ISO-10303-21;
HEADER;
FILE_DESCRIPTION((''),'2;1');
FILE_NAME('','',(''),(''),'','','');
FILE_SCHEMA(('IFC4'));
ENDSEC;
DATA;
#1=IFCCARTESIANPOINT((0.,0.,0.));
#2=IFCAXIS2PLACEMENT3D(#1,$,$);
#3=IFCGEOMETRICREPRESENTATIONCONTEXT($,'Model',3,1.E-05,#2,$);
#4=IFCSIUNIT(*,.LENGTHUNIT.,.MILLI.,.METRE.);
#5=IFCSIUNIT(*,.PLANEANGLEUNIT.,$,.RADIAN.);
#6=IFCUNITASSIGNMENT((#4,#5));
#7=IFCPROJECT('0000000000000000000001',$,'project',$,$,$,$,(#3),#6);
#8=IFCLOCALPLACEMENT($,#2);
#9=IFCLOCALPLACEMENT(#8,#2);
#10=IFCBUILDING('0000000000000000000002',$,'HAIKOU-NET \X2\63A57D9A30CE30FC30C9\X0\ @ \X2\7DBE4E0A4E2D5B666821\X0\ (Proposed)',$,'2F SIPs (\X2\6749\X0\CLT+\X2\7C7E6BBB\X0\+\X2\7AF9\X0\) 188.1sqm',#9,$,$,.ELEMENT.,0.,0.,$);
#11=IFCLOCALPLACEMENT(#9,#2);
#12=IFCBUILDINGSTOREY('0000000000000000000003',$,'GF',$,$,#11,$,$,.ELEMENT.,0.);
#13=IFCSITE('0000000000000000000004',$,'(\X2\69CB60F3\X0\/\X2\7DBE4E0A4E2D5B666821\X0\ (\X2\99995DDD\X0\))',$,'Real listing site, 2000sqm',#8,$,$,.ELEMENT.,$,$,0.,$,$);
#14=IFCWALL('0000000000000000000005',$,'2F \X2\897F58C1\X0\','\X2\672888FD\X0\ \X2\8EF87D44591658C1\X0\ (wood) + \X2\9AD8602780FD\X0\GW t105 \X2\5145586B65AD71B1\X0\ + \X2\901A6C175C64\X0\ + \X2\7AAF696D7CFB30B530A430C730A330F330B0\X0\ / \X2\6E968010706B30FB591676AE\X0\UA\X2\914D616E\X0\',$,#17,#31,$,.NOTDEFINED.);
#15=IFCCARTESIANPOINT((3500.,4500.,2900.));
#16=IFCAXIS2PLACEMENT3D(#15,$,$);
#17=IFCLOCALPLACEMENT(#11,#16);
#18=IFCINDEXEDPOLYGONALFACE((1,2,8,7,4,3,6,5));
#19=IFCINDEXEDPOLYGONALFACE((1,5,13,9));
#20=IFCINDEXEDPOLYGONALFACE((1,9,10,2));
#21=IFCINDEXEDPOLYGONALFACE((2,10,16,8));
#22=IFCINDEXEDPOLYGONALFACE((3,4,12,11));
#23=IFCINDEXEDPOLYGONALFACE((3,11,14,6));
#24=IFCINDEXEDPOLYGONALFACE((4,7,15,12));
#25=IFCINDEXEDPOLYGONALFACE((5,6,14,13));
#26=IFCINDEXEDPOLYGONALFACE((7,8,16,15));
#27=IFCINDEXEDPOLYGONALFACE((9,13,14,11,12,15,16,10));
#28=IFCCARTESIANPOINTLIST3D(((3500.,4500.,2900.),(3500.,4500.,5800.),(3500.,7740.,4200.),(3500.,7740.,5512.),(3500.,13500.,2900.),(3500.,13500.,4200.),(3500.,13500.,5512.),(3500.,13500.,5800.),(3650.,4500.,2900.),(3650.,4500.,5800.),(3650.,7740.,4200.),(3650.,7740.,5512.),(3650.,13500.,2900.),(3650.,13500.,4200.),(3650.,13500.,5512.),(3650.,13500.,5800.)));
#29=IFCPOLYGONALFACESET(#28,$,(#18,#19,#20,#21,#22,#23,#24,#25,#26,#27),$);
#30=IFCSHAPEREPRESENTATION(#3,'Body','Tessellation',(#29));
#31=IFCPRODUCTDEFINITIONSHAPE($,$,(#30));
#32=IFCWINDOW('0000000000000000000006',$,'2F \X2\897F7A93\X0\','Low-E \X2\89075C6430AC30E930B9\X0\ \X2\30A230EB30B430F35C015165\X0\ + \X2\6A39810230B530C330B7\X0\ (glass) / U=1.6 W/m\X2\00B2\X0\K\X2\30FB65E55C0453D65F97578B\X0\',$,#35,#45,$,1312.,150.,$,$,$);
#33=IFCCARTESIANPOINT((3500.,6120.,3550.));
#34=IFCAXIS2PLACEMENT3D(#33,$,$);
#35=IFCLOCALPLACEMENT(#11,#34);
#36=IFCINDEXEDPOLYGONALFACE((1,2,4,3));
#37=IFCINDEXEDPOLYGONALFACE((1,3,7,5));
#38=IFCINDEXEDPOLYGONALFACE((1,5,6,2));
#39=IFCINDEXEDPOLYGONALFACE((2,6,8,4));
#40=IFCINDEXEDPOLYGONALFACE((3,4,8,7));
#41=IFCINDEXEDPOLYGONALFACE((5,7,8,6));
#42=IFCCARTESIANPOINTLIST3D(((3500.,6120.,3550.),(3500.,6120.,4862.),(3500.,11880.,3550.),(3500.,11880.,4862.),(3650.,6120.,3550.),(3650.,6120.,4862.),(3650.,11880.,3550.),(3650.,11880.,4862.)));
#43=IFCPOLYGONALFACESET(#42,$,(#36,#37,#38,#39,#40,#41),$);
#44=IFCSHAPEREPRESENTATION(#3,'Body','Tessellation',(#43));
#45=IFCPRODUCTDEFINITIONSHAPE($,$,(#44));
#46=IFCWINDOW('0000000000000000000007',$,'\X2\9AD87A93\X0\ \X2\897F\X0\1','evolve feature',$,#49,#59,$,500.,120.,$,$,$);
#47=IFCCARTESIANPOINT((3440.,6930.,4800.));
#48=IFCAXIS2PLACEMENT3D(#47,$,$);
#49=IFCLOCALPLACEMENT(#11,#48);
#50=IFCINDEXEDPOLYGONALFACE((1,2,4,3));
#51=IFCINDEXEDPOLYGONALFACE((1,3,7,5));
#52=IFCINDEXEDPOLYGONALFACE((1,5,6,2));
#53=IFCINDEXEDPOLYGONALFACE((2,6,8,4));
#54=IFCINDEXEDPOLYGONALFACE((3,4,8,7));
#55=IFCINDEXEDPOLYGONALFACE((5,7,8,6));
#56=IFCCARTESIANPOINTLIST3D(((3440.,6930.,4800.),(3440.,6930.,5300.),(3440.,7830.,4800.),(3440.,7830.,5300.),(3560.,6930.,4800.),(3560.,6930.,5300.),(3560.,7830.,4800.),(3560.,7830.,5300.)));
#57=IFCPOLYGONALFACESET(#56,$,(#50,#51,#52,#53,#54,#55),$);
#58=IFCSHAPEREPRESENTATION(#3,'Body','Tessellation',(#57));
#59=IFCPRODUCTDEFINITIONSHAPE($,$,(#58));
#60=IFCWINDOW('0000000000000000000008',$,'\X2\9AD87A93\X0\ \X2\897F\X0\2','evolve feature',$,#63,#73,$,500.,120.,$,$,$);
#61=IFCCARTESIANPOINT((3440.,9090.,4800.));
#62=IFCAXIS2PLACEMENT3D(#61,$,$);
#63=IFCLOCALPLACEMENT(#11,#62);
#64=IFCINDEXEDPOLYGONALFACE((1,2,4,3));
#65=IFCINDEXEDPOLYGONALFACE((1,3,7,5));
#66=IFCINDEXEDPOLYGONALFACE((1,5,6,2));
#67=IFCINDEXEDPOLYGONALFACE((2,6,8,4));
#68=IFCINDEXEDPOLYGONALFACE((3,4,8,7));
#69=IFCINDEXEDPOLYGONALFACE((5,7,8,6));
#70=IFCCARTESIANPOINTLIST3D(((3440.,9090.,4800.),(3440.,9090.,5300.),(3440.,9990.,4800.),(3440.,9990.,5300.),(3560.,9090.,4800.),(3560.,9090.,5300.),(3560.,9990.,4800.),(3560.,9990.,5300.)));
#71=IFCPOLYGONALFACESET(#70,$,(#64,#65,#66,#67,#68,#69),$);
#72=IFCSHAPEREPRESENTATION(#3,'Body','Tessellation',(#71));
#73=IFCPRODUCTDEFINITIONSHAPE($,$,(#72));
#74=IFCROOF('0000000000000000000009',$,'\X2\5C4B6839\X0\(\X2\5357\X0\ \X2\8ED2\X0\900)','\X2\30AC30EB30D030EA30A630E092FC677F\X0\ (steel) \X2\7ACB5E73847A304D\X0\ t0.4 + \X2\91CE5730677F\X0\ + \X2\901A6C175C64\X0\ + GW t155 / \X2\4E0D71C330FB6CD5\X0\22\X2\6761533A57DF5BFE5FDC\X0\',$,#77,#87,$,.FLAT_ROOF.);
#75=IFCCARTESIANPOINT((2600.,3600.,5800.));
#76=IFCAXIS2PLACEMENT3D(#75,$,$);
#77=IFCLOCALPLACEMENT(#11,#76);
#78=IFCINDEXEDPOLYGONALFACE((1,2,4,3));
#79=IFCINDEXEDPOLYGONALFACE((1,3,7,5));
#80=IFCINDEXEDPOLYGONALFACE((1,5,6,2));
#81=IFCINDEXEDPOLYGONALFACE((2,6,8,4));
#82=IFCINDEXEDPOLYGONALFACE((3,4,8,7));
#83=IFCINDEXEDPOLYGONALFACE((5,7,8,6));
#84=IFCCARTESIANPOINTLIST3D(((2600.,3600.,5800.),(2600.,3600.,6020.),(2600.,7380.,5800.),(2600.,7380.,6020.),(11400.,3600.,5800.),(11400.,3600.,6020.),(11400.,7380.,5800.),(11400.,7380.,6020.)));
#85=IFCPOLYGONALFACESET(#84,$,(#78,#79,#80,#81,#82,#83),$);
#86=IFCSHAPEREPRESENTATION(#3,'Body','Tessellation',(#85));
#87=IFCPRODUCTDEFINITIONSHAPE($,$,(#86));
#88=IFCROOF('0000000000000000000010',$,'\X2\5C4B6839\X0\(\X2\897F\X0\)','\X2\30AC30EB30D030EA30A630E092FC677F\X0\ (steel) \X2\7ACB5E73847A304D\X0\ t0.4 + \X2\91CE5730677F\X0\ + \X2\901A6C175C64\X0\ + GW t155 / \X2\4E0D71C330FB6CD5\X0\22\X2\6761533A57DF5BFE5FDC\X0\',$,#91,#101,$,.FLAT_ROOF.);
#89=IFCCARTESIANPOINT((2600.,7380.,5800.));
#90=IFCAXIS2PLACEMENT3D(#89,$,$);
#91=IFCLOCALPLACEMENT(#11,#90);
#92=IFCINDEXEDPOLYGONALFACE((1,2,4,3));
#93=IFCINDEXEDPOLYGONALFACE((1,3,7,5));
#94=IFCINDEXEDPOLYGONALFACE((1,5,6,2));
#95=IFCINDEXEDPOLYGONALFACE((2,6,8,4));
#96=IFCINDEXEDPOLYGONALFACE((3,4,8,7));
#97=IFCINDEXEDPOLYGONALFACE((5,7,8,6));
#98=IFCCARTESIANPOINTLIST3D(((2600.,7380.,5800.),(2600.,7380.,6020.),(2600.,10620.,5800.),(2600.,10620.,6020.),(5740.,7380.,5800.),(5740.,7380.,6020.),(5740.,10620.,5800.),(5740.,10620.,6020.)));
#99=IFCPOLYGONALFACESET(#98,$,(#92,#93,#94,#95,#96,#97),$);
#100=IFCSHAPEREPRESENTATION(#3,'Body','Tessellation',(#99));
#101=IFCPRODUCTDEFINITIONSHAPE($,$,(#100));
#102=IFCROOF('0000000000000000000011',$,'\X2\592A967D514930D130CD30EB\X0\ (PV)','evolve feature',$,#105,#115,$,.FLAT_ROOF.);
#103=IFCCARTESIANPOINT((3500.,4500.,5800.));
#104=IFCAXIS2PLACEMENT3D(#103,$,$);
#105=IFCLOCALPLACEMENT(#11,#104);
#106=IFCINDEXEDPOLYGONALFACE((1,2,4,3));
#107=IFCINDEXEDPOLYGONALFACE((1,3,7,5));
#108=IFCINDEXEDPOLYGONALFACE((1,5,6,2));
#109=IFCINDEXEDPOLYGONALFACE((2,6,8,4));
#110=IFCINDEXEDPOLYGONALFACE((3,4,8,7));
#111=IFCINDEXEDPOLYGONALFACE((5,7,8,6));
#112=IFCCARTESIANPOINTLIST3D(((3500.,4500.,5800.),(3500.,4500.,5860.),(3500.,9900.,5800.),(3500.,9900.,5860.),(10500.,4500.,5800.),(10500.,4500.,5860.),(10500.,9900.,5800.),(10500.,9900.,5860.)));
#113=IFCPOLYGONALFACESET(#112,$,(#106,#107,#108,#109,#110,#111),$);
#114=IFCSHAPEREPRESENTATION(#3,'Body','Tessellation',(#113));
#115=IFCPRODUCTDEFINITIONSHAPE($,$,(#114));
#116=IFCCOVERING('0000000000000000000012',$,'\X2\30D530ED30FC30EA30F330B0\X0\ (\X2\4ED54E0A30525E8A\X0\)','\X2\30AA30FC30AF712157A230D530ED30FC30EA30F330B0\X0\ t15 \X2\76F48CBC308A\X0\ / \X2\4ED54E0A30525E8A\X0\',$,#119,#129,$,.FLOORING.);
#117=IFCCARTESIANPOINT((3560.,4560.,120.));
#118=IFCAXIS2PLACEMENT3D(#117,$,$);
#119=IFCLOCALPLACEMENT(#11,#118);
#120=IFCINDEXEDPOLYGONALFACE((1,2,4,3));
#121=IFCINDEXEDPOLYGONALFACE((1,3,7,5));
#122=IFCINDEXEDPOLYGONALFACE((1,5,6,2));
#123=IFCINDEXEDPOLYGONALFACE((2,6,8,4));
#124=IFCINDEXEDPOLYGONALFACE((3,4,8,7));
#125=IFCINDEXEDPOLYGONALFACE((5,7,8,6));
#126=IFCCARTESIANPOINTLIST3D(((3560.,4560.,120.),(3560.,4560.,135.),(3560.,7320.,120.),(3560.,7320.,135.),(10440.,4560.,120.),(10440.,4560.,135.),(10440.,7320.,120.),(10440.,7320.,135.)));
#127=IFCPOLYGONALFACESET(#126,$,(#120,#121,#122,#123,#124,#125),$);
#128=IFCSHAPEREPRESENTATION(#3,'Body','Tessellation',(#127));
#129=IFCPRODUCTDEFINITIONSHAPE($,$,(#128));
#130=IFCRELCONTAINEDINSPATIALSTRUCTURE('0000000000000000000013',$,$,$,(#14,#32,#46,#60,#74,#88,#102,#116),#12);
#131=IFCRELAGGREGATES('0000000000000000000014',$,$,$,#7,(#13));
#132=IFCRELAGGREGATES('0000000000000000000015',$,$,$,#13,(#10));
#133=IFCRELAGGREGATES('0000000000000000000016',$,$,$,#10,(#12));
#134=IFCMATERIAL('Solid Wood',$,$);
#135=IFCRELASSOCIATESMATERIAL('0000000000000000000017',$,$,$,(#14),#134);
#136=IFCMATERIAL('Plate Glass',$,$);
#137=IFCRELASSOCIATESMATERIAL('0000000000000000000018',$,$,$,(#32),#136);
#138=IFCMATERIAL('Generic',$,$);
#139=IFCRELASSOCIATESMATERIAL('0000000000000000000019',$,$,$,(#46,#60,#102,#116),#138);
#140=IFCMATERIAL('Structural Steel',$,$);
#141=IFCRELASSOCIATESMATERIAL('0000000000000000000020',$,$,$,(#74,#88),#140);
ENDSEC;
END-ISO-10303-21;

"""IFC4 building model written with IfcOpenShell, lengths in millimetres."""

from ifc_helpers import new_model, si_unit, frame, frame_2d, origin, place, context, project, spatial, rectangle, extrude, material, element, fill, save


model = new_model("IFC4")

# Units and contexts
model_context = context("Model", 3, precision=1e-05, world=origin())
ifc_project = project(units=[si_unit("LENGTHUNIT", "METRE", prefix="MILLI"), si_unit("PLANEANGLEUNIT", "RADIAN")], contexts=[model_context])

# Site, building, storey
site_placement = place(None, origin())
site = spatial("IfcSite", under=ifc_project, at=site_placement, Name="(構想/綾上中学校 (香川))", ObjectType="Real listing site, 2000sqm", CompositionType="ELEMENT", RefElevation=0.0)
building_placement = place(site_placement, origin())
building = spatial("IfcBuilding", under=site, at=building_placement, Name="HAIKOU-NET 接続ノード @ 綾上中学校 (Proposed)", ObjectType="2F SIPs (杉CLT+籾殻+竹) 188.1sqm", CompositionType="ELEMENT", ElevationOfRefHeight=0.0, ElevationOfTerrain=0.0)
storey_placement = place(building_placement, origin())
storey = spatial("IfcBuildingStorey", under=building, at=storey_placement, Name="GF", CompositionType="ELEMENT", Elevation=0.0)

# Shared definitions
ifc_material_1 = material(Name="Solid Wood")
ifc_material_2 = material(Name="Generic")

# Shared definitions
ifc_material_3 = material(Name="Plate Glass")

# Wall, openings, windows
wall_1_placement = place(storey_placement, frame((3500.0, 4500.0, 2900.0)))
wall_1 = element("IfcWall", 1, at=wall_1_placement, inside=storey, material=ifc_material_1, Name="2F 西壁", Description="木製 軸組外壁 (wood) + 高性能GW t105 充填断熱 + 通気層 + 窯業系サイディング / 準耐火・外皮UA配慮", PredefinedType="NOTDEFINED", context=model_context, shape_type="SweptSolid", body=[
    extrude(rectangle(XDim=150.0, YDim=9000.0, at=frame_2d((75.0, 4500.0))), frame((3500.0, 4500.0, 2900.0)), (0.0, 0.0, 1.0), 2900.0),
])
opening_1_placement = place(storey_placement, frame((3500.0, 6120.0, 3550.0)))
opening_1 = element("IfcOpeningElement", 2, at=opening_1_placement, cuts=wall_1, PredefinedType="NOTDEFINED", context=model_context, shape_type="SweptSolid", body=[
    extrude(rectangle(XDim=150.0, YDim=5760.0, at=frame_2d((75.0, 2880.0))), frame((3500.0, 6120.0, 3550.0)), (0.0, 0.0, 1.0), 1312.0),
])
opening_2_placement = place(storey_placement, frame((3440.0, 6930.0, 4800.0)))
opening_2 = element("IfcOpeningElement", 3, at=opening_2_placement, cuts=wall_1, PredefinedType="NOTDEFINED", context=model_context, shape_type="SweptSolid", body=[
    extrude(rectangle(XDim=120.0, YDim=900.0, at=frame_2d((60.0, 450.0))), frame((3440.0, 6930.0, 4800.0)), (0.0, 0.0, 1.0), 500.0),
])
opening_3_placement = place(storey_placement, frame((3440.0, 9090.0, 4800.0)))
opening_3 = element("IfcOpeningElement", 4, at=opening_3_placement, cuts=wall_1, PredefinedType="NOTDEFINED", context=model_context, shape_type="SweptSolid", body=[
    extrude(rectangle(XDim=120.0, YDim=900.0, at=frame_2d((60.0, 450.0))), frame((3440.0, 9090.0, 4800.0)), (0.0, 0.0, 1.0), 500.0),
])
window_1_placement = place(storey_placement, frame((3500.0, 6120.0, 3550.0)))
window_1 = element("IfcWindow", 5, at=window_1_placement, inside=storey, material=ifc_material_3, Name="2F 西窓", Description="Low-E 複層ガラス アルゴン封入 + 樹脂サッシ (glass) / U=1.6 W/m²K・日射取得型", OverallHeight=1312.0, OverallWidth=150.0, context=model_context, shape_type="SweptSolid", body=[
    extrude(rectangle(XDim=150.0, YDim=5760.0, at=frame_2d((75.0, 2880.0))), frame((3500.0, 6120.0, 3550.0)), (0.0, 0.0, 1.0), 1312.0),
])
fill(opening_1, window_1)
window_2_placement = place(storey_placement, frame((3440.0, 6930.0, 4800.0)))
window_2 = element("IfcWindow", 6, at=window_2_placement, inside=storey, material=ifc_material_2, Name="高窓 西1", Description="evolve feature", OverallHeight=500.0, OverallWidth=120.0, context=model_context, shape_type="SweptSolid", body=[
    extrude(rectangle(XDim=120.0, YDim=900.0, at=frame_2d((60.0, 450.0))), frame((3440.0, 6930.0, 4800.0)), (0.0, 0.0, 1.0), 500.0),
])
fill(opening_2, window_2)
window_3_placement = place(storey_placement, frame((3440.0, 9090.0, 4800.0)))
window_3 = element("IfcWindow", 7, at=window_3_placement, inside=storey, material=ifc_material_2, Name="高窓 西2", Description="evolve feature", OverallHeight=500.0, OverallWidth=120.0, context=model_context, shape_type="SweptSolid", body=[
    extrude(rectangle(XDim=120.0, YDim=900.0, at=frame_2d((60.0, 450.0))), frame((3440.0, 9090.0, 4800.0)), (0.0, 0.0, 1.0), 500.0),
])
fill(opening_3, window_3)

# Roofs
ifc_material_4 = material(Name="Structural Steel")
roof_1_placement = place(storey_placement, frame((2600.0, 3600.0, 5800.0)))
element("IfcRoof", 8, at=roof_1_placement, inside=storey, material=ifc_material_4, Name="屋根(南 軒900)", Description="ガルバリウム鋼板 (steel) 立平葺き t0.4 + 野地板 + 通気層 + GW t155 / 不燃・法22条区域対応", PredefinedType="FLAT_ROOF", context=model_context, shape_type="SweptSolid", body=[
    extrude(rectangle(XDim=8800.0, YDim=3780.0, at=frame_2d((4400.0, 1890.0))), frame((2600.0, 3600.0, 5800.0)), (0.0, 0.0, 1.0), 220.0),
])
roof_2_placement = place(storey_placement, frame((2600.0, 7380.0, 5800.0)))
element("IfcRoof", 9, at=roof_2_placement, inside=storey, material=ifc_material_4, Name="屋根(西)", Description="ガルバリウム鋼板 (steel) 立平葺き t0.4 + 野地板 + 通気層 + GW t155 / 不燃・法22条区域対応", PredefinedType="FLAT_ROOF", context=model_context, shape_type="SweptSolid", body=[
    extrude(rectangle(XDim=3140.0, YDim=3240.0, at=frame_2d((1570.0, 1620.0))), frame((2600.0, 7380.0, 5800.0)), (0.0, 0.0, 1.0), 220.0),
])
roof_3_placement = place(storey_placement, frame((3500.0, 4500.0, 5800.0)))
element("IfcRoof", 10, at=roof_3_placement, inside=storey, material=ifc_material_2, Name="太陽光パネル (PV)", Description="evolve feature", PredefinedType="FLAT_ROOF", context=model_context, shape_type="SweptSolid", body=[
    extrude(rectangle(XDim=7000.0, YDim=5400.0, at=frame_2d((3500.0, 2700.0))), frame((3500.0, 4500.0, 5800.0)), (0.0, 0.0, 1.0), 60.0),
])

# Covering
covering_placement = place(storey_placement, frame((3560.0, 4560.0, 120.0)))
element("IfcCovering", 11, at=covering_placement, inside=storey, material=ifc_material_2, Name="フローリング (仕上げ床)", Description="オーク無垢フローリング t15 直貼り / 仕上げ床", PredefinedType="FLOORING", context=model_context, shape_type="SweptSolid", body=[
    extrude(rectangle(XDim=6880.0, YDim=2760.0, at=frame_2d((3440.0, 1380.0))), frame((3560.0, 4560.0, 120.0)), (0.0, 0.0, 1.0), 15.0),
])

save(model, "model.ifc")
